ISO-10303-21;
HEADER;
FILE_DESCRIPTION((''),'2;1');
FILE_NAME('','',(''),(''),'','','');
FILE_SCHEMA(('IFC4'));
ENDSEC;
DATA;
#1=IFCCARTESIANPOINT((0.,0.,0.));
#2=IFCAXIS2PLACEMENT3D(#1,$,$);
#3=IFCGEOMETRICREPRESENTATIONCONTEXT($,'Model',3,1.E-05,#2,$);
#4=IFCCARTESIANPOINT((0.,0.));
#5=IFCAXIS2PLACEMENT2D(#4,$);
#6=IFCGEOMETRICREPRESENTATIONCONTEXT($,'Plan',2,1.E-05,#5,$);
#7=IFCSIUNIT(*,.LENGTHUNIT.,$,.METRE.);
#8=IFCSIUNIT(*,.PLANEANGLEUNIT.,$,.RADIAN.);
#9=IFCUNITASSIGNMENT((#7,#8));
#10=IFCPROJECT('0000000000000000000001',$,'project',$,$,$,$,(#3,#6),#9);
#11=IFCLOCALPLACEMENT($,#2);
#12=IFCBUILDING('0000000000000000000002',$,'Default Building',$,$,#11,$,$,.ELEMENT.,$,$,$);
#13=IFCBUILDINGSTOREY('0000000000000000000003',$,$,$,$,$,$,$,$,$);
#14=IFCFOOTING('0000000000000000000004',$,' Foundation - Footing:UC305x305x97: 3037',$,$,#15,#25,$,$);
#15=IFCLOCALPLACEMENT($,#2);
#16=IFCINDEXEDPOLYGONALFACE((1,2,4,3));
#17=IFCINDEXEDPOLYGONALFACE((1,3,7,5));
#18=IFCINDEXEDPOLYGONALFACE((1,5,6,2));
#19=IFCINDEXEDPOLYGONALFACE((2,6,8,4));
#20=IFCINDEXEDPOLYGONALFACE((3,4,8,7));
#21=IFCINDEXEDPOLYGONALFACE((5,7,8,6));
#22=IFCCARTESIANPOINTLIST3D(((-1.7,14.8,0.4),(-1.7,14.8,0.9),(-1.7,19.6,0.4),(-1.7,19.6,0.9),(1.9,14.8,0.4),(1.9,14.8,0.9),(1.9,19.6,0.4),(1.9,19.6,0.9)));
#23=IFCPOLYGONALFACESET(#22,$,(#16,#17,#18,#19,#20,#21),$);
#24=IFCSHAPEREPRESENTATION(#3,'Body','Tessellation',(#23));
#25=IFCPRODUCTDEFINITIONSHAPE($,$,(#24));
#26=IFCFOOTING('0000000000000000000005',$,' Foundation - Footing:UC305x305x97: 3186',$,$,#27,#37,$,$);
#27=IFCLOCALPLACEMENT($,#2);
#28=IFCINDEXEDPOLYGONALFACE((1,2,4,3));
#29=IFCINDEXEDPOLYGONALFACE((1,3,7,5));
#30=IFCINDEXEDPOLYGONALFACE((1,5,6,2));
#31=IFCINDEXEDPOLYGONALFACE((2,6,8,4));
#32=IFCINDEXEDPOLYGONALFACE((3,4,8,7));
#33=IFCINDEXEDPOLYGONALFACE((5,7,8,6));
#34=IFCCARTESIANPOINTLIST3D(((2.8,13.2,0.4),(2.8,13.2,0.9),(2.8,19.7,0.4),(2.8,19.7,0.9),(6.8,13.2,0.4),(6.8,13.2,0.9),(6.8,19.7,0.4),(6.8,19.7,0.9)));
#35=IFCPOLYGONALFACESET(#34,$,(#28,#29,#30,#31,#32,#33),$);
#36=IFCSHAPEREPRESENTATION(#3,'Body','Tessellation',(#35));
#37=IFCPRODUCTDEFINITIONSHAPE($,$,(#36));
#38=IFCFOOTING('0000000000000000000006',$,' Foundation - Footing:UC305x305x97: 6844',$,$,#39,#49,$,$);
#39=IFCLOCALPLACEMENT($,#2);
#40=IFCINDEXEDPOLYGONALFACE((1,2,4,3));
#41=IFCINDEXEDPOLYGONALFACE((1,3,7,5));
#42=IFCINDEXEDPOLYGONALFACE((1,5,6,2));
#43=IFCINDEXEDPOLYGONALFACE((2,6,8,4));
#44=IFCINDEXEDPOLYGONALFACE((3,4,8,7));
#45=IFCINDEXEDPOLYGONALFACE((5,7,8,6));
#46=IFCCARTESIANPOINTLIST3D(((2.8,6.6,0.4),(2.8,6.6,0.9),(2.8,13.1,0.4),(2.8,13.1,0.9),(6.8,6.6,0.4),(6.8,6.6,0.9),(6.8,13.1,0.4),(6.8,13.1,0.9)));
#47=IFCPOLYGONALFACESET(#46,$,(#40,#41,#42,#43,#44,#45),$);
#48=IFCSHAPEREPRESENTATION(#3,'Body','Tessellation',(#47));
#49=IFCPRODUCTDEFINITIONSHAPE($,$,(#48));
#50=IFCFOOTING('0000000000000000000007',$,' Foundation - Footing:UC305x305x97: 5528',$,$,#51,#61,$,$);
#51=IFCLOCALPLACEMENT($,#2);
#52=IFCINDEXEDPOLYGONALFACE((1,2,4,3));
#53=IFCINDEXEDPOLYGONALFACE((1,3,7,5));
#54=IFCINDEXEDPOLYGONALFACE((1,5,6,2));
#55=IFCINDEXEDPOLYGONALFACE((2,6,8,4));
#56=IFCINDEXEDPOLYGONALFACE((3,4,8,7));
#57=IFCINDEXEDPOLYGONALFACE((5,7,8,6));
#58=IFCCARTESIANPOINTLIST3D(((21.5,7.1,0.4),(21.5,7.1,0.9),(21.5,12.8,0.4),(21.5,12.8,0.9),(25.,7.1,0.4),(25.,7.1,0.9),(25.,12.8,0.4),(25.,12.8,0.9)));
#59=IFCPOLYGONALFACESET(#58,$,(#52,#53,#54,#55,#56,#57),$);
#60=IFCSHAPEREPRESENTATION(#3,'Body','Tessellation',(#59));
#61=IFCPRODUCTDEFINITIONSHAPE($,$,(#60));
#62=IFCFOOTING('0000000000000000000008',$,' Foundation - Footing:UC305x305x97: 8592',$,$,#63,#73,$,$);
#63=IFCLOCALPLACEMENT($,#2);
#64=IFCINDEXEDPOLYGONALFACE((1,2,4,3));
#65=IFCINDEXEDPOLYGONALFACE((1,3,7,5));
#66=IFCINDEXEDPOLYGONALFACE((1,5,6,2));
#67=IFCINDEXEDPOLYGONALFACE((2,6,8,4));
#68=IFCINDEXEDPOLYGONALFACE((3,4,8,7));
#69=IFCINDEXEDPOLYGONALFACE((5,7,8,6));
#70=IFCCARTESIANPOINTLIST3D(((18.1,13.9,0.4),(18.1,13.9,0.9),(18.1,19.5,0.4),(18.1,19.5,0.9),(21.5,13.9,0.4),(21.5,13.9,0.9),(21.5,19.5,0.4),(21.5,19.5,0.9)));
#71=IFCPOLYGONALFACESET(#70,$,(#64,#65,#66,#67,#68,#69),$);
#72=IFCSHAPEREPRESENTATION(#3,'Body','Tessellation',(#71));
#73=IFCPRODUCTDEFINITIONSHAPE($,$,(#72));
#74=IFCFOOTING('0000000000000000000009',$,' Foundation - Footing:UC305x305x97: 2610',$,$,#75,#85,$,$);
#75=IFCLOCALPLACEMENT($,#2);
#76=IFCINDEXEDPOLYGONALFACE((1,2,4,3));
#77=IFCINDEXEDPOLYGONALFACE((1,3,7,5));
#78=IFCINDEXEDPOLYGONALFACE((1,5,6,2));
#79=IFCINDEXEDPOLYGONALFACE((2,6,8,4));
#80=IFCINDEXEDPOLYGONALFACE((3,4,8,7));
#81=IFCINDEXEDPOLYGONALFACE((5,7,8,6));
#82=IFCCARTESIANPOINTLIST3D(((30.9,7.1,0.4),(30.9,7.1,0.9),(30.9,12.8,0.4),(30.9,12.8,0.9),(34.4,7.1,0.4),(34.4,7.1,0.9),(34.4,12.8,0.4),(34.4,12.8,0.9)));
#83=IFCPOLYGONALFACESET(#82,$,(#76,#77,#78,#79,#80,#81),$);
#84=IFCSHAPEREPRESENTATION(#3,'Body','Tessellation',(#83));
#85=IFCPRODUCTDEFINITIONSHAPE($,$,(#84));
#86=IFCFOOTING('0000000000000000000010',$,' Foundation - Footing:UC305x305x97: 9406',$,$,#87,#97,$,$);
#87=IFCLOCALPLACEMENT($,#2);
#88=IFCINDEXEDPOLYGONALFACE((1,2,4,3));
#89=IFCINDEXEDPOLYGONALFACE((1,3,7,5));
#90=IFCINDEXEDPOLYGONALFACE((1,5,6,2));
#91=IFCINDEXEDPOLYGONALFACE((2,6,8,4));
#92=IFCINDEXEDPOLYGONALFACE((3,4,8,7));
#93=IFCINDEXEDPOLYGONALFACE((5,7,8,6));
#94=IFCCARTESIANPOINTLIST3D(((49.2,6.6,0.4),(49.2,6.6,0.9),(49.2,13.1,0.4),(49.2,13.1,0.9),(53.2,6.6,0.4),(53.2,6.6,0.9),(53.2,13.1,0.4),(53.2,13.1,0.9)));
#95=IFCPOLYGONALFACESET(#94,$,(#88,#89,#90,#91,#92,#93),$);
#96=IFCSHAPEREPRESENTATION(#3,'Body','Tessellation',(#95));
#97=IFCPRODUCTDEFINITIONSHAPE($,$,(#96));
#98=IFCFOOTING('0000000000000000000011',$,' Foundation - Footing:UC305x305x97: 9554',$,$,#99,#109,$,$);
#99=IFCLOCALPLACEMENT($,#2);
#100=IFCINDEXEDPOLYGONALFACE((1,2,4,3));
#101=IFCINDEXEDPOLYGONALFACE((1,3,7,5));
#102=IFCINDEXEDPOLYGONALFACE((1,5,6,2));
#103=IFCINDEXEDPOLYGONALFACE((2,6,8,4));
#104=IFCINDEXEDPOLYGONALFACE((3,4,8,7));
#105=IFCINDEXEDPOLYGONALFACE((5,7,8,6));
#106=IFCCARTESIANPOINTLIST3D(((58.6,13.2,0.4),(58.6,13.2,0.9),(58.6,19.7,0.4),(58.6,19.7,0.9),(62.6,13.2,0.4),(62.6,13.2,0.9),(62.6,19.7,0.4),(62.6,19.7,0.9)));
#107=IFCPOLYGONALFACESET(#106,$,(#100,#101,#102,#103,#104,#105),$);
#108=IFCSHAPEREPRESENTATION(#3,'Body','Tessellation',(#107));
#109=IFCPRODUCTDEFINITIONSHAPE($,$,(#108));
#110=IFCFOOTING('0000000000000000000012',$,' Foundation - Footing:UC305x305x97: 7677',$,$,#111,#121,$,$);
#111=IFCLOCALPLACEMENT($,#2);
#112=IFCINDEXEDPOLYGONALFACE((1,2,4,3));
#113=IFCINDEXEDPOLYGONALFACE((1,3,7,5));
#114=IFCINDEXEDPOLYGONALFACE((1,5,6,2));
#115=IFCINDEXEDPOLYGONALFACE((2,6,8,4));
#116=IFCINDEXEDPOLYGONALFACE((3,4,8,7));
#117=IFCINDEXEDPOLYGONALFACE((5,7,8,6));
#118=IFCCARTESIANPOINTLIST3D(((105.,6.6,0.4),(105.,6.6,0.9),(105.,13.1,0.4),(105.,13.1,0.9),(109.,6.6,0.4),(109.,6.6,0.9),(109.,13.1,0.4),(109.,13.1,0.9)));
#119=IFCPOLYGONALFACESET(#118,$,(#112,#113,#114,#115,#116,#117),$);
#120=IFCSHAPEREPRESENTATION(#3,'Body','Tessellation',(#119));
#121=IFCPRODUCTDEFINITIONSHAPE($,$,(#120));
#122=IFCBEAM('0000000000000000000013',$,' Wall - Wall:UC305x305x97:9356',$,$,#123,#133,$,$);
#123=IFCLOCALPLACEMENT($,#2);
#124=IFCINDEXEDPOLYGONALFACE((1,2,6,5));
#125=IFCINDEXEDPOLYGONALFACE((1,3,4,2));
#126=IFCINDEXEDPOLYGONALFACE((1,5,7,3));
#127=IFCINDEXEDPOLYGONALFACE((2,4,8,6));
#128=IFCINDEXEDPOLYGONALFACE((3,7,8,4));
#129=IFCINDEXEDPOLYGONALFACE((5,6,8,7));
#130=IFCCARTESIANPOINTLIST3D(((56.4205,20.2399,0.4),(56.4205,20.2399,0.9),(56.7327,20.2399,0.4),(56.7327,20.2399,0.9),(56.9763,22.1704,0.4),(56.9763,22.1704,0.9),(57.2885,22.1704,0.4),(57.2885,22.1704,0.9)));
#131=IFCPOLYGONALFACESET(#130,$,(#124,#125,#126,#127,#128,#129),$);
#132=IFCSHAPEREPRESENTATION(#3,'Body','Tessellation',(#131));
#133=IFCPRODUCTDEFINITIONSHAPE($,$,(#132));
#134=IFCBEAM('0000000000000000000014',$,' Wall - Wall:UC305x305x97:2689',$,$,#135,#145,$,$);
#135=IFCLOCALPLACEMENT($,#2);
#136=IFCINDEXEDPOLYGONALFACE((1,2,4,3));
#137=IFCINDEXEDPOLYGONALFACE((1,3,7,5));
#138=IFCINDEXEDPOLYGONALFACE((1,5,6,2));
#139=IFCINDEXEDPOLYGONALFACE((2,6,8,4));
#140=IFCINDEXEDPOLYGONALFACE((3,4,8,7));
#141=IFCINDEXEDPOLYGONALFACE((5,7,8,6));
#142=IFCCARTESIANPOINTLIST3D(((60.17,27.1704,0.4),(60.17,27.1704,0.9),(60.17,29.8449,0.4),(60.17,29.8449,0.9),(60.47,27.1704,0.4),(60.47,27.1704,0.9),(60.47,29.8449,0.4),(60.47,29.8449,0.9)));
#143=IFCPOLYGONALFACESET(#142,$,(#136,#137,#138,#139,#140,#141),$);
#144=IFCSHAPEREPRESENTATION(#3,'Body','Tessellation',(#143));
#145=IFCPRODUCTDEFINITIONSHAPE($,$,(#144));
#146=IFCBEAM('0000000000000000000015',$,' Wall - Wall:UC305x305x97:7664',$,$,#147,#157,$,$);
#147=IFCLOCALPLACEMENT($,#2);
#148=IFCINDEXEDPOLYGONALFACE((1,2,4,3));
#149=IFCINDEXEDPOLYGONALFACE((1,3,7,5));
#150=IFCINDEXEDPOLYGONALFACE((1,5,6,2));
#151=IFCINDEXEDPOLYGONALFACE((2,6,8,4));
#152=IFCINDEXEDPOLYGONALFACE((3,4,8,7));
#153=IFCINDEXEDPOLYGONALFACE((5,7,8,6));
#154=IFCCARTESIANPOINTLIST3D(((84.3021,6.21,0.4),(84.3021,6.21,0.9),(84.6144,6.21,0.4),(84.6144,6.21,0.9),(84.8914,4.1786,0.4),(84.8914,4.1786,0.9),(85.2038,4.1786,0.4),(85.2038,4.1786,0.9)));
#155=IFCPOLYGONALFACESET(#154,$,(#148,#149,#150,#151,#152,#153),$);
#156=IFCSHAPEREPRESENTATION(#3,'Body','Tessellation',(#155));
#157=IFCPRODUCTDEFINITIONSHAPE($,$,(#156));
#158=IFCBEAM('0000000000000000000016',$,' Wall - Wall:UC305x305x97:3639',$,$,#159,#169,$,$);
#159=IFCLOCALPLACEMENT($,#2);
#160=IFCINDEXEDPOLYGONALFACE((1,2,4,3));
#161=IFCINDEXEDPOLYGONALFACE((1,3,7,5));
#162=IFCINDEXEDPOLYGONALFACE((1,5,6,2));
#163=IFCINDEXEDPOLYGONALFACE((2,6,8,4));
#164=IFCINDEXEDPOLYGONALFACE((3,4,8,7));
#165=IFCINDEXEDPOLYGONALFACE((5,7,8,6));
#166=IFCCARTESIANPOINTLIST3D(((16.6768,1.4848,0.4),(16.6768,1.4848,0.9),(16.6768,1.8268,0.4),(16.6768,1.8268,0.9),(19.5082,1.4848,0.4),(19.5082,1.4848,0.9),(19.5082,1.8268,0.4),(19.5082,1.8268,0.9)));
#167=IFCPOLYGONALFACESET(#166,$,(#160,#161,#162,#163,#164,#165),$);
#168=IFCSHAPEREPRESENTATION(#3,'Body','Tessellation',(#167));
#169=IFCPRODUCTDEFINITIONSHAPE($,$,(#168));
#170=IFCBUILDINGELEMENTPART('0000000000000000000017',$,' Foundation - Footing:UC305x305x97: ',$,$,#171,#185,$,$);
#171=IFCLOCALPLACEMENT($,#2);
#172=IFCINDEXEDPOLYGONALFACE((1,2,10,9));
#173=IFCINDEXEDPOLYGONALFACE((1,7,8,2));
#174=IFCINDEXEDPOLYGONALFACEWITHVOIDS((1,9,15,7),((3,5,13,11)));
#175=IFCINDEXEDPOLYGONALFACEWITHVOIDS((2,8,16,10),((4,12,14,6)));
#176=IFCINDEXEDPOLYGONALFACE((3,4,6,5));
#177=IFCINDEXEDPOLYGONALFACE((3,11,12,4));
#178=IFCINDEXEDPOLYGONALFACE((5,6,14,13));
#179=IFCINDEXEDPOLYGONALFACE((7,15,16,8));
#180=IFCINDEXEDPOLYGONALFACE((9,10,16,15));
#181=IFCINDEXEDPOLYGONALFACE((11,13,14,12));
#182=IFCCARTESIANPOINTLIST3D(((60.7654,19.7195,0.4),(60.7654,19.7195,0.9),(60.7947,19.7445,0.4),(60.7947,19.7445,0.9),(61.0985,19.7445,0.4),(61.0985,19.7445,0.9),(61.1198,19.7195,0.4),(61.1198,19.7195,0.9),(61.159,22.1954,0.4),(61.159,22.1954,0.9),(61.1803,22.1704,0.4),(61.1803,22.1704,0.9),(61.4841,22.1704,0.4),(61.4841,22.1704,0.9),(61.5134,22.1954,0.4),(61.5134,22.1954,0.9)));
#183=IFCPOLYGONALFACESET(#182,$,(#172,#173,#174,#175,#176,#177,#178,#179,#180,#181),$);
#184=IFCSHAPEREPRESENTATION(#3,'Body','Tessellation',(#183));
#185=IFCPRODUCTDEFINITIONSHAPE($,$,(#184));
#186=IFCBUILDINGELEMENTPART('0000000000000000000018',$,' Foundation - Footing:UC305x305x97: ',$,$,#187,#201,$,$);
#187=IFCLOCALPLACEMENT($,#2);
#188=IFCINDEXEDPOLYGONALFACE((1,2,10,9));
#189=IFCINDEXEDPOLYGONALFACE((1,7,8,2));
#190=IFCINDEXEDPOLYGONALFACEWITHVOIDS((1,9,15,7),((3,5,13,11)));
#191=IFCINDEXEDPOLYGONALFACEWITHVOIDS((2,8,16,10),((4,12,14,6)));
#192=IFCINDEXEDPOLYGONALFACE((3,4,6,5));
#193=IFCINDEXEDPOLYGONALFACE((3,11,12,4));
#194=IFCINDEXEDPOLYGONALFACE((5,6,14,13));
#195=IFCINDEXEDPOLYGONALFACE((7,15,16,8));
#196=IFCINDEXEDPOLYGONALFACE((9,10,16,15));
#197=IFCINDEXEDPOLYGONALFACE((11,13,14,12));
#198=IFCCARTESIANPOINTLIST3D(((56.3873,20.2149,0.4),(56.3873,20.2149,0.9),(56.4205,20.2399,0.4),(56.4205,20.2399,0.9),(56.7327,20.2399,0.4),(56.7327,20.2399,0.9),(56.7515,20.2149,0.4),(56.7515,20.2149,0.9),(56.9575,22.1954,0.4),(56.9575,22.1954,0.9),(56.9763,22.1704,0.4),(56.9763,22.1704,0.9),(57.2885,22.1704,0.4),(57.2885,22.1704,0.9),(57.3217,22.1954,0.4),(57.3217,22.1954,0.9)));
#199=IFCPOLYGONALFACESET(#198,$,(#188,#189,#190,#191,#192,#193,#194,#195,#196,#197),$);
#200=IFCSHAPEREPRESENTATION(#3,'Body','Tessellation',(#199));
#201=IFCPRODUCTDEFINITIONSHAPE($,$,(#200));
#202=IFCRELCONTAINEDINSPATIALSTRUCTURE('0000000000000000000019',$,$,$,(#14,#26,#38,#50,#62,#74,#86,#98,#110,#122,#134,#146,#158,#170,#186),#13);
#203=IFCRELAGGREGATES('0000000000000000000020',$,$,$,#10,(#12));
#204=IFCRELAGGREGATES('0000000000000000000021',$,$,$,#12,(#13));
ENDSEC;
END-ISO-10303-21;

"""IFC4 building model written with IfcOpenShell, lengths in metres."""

from ifc_helpers import new_model, si_unit, origin, origin_2d, place, context, project, spatial, polyline, outline, extrude, element, save


model = new_model("IFC4")

# Units and contexts
model_context = context("Model", 3, precision=1e-05, world=origin())
plan_context = context("Plan", 2, precision=1e-05, world=origin_2d())
ifc_project = project(units=[si_unit("LENGTHUNIT", "METRE"), si_unit("PLANEANGLEUNIT", "RADIAN")], contexts=[model_context, plan_context])

# Building, storey
building_placement = place(None, origin())
building = spatial("IfcBuilding", under=ifc_project, at=building_placement, Name="Default Building", CompositionType="ELEMENT")
storey = spatial("IfcBuildingStorey", under=building)

# Footings
element("IfcFooting", 1, inside=storey, Name=" Foundation - Footing:UC305x305x97: 3037", context=model_context, shape_type="SweptSolid", body=[
    extrude(outline(polyline([(1.9, 19.6, 0.4), (-1.7, 19.6, 0.4), (-1.7, 14.8, 0.4), (1.9, 14.8, 0.4), (1.9, 19.6, 0.4)])), None, (0.0, 0.0, 1.0), 0.5),
])
element("IfcFooting", 2, inside=storey, Name=" Foundation - Footing:UC305x305x97: 3186", context=model_context, shape_type="SweptSolid", body=[
    extrude(outline(polyline([(6.8, 19.7, 0.4), (2.8, 19.7, 0.4), (2.8, 13.2, 0.4), (6.8, 13.2, 0.4), (6.8, 19.7, 0.4)])), None, (0.0, 0.0, 1.0), 0.5),
])
element("IfcFooting", 3, inside=storey, Name=" Foundation - Footing:UC305x305x97: 6844", context=model_context, shape_type="SweptSolid", body=[
    extrude(outline(polyline([(6.8, 13.1, 0.4), (2.8, 13.1, 0.4), (2.8, 6.6, 0.4), (6.8, 6.6, 0.4), (6.8, 13.1, 0.4)])), None, (0.0, 0.0, 1.0), 0.5),
])
element("IfcFooting", 4, inside=storey, Name=" Foundation - Footing:UC305x305x97: 5528", context=model_context, shape_type="SweptSolid", body=[
    extrude(outline(polyline([(25.0, 12.8, 0.4), (21.5, 12.8, 0.4), (21.5, 7.1, 0.4), (25.0, 7.1, 0.4), (25.0, 12.8, 0.4)])), None, (0.0, 0.0, 1.0), 0.5),
])
element("IfcFooting", 5, inside=storey, Name=" Foundation - Footing:UC305x305x97: 8592", context=model_context, shape_type="SweptSolid", body=[
    extrude(outline(polyline([(21.5, 19.5, 0.4), (18.1, 19.5, 0.4), (18.1, 13.9, 0.4), (21.5, 13.9, 0.4), (21.5, 19.5, 0.4)])), None, (0.0, 0.0, 1.0), 0.5),
])
element("IfcFooting", 6, inside=storey, Name=" Foundation - Footing:UC305x305x97: 2610", context=model_context, shape_type="SweptSolid", body=[
    extrude(outline(polyline([(34.4, 12.8, 0.4), (30.9, 12.8, 0.4), (30.9, 7.1, 0.4), (34.4, 7.1, 0.4), (34.4, 12.8, 0.4)])), None, (0.0, 0.0, 1.0), 0.5),
])
element("IfcFooting", 7, inside=storey, Name=" Foundation - Footing:UC305x305x97: 9406", context=model_context, shape_type="SweptSolid", body=[
    extrude(outline(polyline([(53.2, 13.1, 0.4), (49.2, 13.1, 0.4), (49.2, 6.6, 0.4), (53.2, 6.6, 0.4), (53.2, 13.1, 0.4)])), None, (0.0, 0.0, 1.0), 0.5),
])
element("IfcFooting", 8, inside=storey, Name=" Foundation - Footing:UC305x305x97: 9554", context=model_context, shape_type="SweptSolid", body=[
    extrude(outline(polyline([(58.6, 19.7, 0.4), (62.6, 19.7, 0.4), (62.6, 13.2, 0.4), (58.6, 13.2, 0.4), (58.6, 19.7, 0.4)])), None, (0.0, 0.0, 1.0), 0.5),
])
element("IfcFooting", 9, inside=storey, Name=" Foundation - Footing:UC305x305x97: 7677", context=model_context, shape_type="SweptSolid", body=[
    extrude(outline(polyline([(109.0, 13.1, 0.4), (105.0, 13.1, 0.4), (105.0, 6.6, 0.4), (109.0, 6.6, 0.4), (109.0, 13.1, 0.4)])), None, (0.0, 0.0, 1.0), 0.5),
])

# Beams
element("IfcBeam", 10, inside=storey, Name=" Wall - Wall:UC305x305x97:9356", context=model_context, shape_type="SweptSolid", body=[
    extrude(outline(polyline([(56.7327, 20.2399, 0.4), (56.4205, 20.2399, 0.4), (56.9763, 22.1704, 0.4), (57.2885, 22.1704, 0.4), (56.7327, 20.2399, 0.4)])), None, (0.0, 0.0, 1.0), 0.5),
])
element("IfcBeam", 11, inside=storey, Name=" Wall - Wall:UC305x305x97:2689", context=model_context, shape_type="SweptSolid", body=[
    extrude(outline(polyline([(60.47, 27.1704, 0.4), (60.17, 27.1704, 0.4), (60.17, 29.8449, 0.4), (60.47, 29.8449, 0.4), (60.47, 27.1704, 0.4)])), None, (0.0, 0.0, 1.0), 0.5),
])
element("IfcBeam", 12, inside=storey, Name=" Wall - Wall:UC305x305x97:7664", context=model_context, shape_type="SweptSolid", body=[
    extrude(outline(polyline([(84.8914, 4.1786, 0.4), (85.2038, 4.1786, 0.4), (84.6144, 6.21, 0.4), (84.3021, 6.21, 0.4), (84.8914, 4.1786, 0.4)])), None, (0.0, 0.0, 1.0), 0.5),
])
element("IfcBeam", 13, inside=storey, Name=" Wall - Wall:UC305x305x97:3639", context=model_context, shape_type="SweptSolid", body=[
    extrude(outline(polyline([(16.6768, 1.4848, 0.4), (19.5082, 1.4848, 0.4), (19.5082, 1.8268, 0.4), (16.6768, 1.8268, 0.4), (16.6768, 1.4848, 0.4)])), None, (0.0, 0.0, 1.0), 0.5),
])

# Building element parts, openings
building_element_part_1 = element("IfcBuildingElementPart", 14, inside=storey, Name=" Foundation - Footing:UC305x305x97: ", context=model_context, shape_type="SweptSolid", body=[
    extrude(outline(polyline([(61.1198, 19.7195, 0.4), (60.7654, 19.7195, 0.4), (61.159, 22.1954, 0.4), (61.5134, 22.1954, 0.4), (61.1198, 19.7195, 0.4)])), None, (0.0, 0.0, 1.0), 0.5),
])
element("IfcOpeningElement", 15, inside=storey, cuts=building_element_part_1, context=model_context, shape_type="SweptSolid", body=[
    extrude(outline(polyline([(61.0985, 19.7445, 0.4), (60.7947, 19.7445, 0.4), (61.1803, 22.1704, 0.4), (61.4841, 22.1704, 0.4), (61.0985, 19.7445, 0.4)])), None, (0.0, 0.0, 1.0), 0.5),
])
building_element_part_2 = element("IfcBuildingElementPart", 16, inside=storey, Name=" Foundation - Footing:UC305x305x97: ", context=model_context, shape_type="SweptSolid", body=[
    extrude(outline(polyline([(56.7515, 20.2149, 0.4), (56.3873, 20.2149, 0.4), (56.9575, 22.1954, 0.4), (57.3217, 22.1954, 0.4), (56.7515, 20.2149, 0.4)])), None, (0.0, 0.0, 1.0), 0.5),
])
element("IfcOpeningElement", 17, inside=storey, cuts=building_element_part_2, context=model_context, shape_type="SweptSolid", body=[
    extrude(outline(polyline([(56.7327, 20.2399, 0.4), (56.4205, 20.2399, 0.4), (56.9763, 22.1704, 0.4), (57.2885, 22.1704, 0.4), (56.7327, 20.2399, 0.4)])), None, (0.0, 0.0, 1.0), 0.5),
])

save(model, "model.ifc")
